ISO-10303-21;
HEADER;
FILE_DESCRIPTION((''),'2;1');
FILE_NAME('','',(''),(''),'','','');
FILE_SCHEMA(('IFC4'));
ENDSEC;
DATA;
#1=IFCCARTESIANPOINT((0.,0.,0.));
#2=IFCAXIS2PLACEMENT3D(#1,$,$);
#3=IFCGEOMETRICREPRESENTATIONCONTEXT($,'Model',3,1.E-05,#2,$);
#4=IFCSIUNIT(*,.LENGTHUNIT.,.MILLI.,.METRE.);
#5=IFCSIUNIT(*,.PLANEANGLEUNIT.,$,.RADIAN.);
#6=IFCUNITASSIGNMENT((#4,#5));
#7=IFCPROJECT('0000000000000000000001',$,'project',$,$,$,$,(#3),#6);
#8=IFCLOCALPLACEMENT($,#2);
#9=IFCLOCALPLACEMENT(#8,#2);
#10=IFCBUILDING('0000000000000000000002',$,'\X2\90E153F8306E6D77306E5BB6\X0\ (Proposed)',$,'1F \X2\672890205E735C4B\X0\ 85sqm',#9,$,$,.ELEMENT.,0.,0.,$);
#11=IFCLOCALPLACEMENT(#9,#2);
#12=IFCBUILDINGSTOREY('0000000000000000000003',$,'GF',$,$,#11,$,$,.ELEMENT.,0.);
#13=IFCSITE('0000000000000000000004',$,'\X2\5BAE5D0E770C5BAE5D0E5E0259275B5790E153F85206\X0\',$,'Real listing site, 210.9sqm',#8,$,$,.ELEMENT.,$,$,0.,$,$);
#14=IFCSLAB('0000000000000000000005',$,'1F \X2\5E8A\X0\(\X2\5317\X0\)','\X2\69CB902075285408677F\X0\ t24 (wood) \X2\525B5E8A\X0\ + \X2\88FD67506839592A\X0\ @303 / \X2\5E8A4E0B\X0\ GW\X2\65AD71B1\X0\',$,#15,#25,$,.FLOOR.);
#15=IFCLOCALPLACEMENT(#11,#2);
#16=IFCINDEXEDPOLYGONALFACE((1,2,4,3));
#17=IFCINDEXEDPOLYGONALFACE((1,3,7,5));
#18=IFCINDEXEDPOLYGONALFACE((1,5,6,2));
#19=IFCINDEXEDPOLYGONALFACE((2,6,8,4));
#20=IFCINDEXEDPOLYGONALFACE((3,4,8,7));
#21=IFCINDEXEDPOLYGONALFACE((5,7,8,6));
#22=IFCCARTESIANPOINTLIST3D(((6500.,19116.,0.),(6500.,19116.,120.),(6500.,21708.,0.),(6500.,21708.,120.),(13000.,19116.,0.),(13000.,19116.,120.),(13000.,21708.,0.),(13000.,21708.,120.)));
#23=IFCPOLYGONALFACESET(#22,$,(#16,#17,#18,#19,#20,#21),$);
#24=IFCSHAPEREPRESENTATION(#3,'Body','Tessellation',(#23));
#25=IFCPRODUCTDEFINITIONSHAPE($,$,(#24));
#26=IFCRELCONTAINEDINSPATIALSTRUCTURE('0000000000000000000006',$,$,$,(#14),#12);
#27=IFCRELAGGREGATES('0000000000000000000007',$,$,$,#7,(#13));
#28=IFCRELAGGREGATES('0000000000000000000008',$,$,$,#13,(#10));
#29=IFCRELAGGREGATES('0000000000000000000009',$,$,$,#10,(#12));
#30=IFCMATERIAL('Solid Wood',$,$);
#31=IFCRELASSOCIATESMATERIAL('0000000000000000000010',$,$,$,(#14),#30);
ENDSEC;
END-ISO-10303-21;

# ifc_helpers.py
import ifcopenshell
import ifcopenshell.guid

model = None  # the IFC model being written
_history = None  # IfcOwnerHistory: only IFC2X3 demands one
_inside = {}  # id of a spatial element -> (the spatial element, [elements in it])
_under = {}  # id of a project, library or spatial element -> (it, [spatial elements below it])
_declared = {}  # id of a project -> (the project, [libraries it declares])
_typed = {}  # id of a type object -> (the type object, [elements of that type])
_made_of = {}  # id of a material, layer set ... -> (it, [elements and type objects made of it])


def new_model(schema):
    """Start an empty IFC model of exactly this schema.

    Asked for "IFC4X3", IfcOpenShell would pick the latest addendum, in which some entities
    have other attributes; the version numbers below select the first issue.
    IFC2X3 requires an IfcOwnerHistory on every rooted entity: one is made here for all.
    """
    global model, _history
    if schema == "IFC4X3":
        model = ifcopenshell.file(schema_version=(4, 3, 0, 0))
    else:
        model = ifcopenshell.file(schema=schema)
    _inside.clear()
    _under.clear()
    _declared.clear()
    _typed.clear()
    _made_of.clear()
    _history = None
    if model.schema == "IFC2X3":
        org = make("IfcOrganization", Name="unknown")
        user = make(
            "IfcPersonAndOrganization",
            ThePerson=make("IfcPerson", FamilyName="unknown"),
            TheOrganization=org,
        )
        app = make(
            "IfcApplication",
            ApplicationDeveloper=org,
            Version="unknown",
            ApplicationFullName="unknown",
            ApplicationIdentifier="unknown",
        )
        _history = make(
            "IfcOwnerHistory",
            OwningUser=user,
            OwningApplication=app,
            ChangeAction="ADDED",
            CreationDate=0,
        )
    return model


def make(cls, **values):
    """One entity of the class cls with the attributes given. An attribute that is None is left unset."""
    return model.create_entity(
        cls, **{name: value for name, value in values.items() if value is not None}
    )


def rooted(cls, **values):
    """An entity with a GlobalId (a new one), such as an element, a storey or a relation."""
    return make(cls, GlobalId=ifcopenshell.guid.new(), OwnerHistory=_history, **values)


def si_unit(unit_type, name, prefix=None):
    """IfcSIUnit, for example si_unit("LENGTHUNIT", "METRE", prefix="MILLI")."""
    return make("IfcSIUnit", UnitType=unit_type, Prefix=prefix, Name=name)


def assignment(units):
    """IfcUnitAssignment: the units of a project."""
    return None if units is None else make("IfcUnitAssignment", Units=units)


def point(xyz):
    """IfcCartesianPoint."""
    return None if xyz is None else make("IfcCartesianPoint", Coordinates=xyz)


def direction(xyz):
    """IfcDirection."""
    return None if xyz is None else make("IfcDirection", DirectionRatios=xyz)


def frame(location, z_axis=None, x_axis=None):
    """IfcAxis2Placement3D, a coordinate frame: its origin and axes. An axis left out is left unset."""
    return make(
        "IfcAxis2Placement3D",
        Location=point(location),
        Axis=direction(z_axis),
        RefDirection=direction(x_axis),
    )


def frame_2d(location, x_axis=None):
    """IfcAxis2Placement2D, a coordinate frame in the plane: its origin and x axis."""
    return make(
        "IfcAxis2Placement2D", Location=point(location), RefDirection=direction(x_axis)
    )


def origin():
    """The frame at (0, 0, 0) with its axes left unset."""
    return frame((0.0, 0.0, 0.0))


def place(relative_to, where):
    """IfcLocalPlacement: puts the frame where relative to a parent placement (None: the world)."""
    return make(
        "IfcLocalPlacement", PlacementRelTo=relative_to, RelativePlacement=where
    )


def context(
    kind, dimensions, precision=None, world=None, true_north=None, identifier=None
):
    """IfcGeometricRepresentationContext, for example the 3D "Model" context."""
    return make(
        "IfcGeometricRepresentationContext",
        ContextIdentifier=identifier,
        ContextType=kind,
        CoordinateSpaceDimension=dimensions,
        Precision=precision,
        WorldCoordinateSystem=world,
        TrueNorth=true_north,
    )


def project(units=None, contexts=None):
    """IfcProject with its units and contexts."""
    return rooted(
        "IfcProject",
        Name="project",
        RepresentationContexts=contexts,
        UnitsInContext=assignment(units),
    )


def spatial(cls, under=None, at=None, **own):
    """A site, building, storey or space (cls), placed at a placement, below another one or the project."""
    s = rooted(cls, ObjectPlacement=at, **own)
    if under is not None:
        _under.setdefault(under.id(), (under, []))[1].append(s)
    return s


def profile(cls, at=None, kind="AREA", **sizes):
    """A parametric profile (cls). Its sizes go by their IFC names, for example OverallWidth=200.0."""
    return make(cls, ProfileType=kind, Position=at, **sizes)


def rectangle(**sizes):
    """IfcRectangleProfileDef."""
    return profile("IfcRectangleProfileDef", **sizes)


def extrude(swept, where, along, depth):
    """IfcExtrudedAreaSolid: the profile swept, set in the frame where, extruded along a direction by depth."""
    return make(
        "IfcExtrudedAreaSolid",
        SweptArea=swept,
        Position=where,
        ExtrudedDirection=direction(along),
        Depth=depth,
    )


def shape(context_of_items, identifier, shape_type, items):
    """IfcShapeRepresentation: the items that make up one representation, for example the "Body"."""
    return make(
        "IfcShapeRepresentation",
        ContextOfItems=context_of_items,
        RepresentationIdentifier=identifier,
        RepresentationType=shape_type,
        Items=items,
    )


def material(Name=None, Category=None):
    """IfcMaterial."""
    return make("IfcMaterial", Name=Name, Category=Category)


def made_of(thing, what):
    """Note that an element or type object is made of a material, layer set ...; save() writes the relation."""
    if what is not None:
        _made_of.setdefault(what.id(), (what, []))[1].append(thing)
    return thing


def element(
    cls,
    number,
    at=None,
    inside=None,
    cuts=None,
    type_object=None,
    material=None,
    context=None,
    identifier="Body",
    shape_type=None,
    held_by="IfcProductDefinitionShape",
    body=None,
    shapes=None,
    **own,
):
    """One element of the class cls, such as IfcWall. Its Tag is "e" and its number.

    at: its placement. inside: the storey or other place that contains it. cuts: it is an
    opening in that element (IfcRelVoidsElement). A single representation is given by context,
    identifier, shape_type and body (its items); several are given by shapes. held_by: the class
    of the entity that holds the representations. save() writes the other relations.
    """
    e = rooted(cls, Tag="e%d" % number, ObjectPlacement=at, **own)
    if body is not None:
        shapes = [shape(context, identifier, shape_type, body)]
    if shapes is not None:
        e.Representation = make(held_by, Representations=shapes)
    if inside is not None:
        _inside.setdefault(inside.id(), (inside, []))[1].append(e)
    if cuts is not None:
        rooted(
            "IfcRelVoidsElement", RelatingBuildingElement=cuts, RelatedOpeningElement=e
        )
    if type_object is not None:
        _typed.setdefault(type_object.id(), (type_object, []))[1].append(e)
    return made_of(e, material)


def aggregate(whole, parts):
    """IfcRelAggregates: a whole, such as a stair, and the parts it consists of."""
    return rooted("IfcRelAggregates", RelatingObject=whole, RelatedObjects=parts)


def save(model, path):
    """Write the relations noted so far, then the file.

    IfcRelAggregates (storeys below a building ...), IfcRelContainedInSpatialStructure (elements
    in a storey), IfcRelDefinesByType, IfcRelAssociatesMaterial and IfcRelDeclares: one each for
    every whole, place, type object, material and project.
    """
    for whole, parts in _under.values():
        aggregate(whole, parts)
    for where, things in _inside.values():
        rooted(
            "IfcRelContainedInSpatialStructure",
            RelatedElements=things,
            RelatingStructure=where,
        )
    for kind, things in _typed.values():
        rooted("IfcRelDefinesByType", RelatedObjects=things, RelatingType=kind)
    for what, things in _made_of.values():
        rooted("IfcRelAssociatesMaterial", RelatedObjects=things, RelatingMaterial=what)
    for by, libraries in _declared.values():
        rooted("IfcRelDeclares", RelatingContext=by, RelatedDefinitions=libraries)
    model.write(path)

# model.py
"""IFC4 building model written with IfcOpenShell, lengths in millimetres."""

from ifc_helpers import new_model, si_unit, frame, frame_2d, origin, place, context, project, spatial, rectangle, extrude, material, element, save


model = new_model("IFC4")

# Units and contexts
model_context = context("Model", 3, precision=1e-05, world=origin())
ifc_project = project(units=[si_unit("LENGTHUNIT", "METRE", prefix="MILLI"), si_unit("PLANEANGLEUNIT", "RADIAN")], contexts=[model_context])

# Site, building, storey
site_placement = place(None, origin())
site = spatial("IfcSite", under=ifc_project, at=site_placement, Name="宮崎県宮崎市大字郡司分", ObjectType="Real listing site, 210.9sqm", CompositionType="ELEMENT", RefElevation=0.0)
building_placement = place(site_placement, origin())
building = spatial("IfcBuilding", under=site, at=building_placement, Name="郡司の海の家 (Proposed)", ObjectType="1F 木造平屋 85sqm", CompositionType="ELEMENT", ElevationOfRefHeight=0.0, ElevationOfTerrain=0.0)
storey_placement = place(building_placement, origin())
storey = spatial("IfcBuildingStorey", under=building, at=storey_placement, Name="GF", CompositionType="ELEMENT", Elevation=0.0)

# Slab
ifc_material_1 = material(Name="Solid Wood")
slab_1_placement = place(storey_placement, frame((3250.0, 9558.0, 0.0)))
element("IfcSlab", 1, at=slab_1_placement, inside=storey, material=ifc_material_1, Name="1F 床(北)", Description="構造用合板 t24 (wood) 剛床 + 製材根太 @303 / 床下 GW断熱", PredefinedType="FLOOR", context=model_context, shape_type="SweptSolid", body=[
    extrude(rectangle(XDim=6500.0, YDim=2592.0, at=frame_2d((3250.0, 1296.0))), frame((3250.0, 9558.0, 0.0)), (0.0, 0.0, 1.0), 120.0),
])

save(model, "model.ifc")
